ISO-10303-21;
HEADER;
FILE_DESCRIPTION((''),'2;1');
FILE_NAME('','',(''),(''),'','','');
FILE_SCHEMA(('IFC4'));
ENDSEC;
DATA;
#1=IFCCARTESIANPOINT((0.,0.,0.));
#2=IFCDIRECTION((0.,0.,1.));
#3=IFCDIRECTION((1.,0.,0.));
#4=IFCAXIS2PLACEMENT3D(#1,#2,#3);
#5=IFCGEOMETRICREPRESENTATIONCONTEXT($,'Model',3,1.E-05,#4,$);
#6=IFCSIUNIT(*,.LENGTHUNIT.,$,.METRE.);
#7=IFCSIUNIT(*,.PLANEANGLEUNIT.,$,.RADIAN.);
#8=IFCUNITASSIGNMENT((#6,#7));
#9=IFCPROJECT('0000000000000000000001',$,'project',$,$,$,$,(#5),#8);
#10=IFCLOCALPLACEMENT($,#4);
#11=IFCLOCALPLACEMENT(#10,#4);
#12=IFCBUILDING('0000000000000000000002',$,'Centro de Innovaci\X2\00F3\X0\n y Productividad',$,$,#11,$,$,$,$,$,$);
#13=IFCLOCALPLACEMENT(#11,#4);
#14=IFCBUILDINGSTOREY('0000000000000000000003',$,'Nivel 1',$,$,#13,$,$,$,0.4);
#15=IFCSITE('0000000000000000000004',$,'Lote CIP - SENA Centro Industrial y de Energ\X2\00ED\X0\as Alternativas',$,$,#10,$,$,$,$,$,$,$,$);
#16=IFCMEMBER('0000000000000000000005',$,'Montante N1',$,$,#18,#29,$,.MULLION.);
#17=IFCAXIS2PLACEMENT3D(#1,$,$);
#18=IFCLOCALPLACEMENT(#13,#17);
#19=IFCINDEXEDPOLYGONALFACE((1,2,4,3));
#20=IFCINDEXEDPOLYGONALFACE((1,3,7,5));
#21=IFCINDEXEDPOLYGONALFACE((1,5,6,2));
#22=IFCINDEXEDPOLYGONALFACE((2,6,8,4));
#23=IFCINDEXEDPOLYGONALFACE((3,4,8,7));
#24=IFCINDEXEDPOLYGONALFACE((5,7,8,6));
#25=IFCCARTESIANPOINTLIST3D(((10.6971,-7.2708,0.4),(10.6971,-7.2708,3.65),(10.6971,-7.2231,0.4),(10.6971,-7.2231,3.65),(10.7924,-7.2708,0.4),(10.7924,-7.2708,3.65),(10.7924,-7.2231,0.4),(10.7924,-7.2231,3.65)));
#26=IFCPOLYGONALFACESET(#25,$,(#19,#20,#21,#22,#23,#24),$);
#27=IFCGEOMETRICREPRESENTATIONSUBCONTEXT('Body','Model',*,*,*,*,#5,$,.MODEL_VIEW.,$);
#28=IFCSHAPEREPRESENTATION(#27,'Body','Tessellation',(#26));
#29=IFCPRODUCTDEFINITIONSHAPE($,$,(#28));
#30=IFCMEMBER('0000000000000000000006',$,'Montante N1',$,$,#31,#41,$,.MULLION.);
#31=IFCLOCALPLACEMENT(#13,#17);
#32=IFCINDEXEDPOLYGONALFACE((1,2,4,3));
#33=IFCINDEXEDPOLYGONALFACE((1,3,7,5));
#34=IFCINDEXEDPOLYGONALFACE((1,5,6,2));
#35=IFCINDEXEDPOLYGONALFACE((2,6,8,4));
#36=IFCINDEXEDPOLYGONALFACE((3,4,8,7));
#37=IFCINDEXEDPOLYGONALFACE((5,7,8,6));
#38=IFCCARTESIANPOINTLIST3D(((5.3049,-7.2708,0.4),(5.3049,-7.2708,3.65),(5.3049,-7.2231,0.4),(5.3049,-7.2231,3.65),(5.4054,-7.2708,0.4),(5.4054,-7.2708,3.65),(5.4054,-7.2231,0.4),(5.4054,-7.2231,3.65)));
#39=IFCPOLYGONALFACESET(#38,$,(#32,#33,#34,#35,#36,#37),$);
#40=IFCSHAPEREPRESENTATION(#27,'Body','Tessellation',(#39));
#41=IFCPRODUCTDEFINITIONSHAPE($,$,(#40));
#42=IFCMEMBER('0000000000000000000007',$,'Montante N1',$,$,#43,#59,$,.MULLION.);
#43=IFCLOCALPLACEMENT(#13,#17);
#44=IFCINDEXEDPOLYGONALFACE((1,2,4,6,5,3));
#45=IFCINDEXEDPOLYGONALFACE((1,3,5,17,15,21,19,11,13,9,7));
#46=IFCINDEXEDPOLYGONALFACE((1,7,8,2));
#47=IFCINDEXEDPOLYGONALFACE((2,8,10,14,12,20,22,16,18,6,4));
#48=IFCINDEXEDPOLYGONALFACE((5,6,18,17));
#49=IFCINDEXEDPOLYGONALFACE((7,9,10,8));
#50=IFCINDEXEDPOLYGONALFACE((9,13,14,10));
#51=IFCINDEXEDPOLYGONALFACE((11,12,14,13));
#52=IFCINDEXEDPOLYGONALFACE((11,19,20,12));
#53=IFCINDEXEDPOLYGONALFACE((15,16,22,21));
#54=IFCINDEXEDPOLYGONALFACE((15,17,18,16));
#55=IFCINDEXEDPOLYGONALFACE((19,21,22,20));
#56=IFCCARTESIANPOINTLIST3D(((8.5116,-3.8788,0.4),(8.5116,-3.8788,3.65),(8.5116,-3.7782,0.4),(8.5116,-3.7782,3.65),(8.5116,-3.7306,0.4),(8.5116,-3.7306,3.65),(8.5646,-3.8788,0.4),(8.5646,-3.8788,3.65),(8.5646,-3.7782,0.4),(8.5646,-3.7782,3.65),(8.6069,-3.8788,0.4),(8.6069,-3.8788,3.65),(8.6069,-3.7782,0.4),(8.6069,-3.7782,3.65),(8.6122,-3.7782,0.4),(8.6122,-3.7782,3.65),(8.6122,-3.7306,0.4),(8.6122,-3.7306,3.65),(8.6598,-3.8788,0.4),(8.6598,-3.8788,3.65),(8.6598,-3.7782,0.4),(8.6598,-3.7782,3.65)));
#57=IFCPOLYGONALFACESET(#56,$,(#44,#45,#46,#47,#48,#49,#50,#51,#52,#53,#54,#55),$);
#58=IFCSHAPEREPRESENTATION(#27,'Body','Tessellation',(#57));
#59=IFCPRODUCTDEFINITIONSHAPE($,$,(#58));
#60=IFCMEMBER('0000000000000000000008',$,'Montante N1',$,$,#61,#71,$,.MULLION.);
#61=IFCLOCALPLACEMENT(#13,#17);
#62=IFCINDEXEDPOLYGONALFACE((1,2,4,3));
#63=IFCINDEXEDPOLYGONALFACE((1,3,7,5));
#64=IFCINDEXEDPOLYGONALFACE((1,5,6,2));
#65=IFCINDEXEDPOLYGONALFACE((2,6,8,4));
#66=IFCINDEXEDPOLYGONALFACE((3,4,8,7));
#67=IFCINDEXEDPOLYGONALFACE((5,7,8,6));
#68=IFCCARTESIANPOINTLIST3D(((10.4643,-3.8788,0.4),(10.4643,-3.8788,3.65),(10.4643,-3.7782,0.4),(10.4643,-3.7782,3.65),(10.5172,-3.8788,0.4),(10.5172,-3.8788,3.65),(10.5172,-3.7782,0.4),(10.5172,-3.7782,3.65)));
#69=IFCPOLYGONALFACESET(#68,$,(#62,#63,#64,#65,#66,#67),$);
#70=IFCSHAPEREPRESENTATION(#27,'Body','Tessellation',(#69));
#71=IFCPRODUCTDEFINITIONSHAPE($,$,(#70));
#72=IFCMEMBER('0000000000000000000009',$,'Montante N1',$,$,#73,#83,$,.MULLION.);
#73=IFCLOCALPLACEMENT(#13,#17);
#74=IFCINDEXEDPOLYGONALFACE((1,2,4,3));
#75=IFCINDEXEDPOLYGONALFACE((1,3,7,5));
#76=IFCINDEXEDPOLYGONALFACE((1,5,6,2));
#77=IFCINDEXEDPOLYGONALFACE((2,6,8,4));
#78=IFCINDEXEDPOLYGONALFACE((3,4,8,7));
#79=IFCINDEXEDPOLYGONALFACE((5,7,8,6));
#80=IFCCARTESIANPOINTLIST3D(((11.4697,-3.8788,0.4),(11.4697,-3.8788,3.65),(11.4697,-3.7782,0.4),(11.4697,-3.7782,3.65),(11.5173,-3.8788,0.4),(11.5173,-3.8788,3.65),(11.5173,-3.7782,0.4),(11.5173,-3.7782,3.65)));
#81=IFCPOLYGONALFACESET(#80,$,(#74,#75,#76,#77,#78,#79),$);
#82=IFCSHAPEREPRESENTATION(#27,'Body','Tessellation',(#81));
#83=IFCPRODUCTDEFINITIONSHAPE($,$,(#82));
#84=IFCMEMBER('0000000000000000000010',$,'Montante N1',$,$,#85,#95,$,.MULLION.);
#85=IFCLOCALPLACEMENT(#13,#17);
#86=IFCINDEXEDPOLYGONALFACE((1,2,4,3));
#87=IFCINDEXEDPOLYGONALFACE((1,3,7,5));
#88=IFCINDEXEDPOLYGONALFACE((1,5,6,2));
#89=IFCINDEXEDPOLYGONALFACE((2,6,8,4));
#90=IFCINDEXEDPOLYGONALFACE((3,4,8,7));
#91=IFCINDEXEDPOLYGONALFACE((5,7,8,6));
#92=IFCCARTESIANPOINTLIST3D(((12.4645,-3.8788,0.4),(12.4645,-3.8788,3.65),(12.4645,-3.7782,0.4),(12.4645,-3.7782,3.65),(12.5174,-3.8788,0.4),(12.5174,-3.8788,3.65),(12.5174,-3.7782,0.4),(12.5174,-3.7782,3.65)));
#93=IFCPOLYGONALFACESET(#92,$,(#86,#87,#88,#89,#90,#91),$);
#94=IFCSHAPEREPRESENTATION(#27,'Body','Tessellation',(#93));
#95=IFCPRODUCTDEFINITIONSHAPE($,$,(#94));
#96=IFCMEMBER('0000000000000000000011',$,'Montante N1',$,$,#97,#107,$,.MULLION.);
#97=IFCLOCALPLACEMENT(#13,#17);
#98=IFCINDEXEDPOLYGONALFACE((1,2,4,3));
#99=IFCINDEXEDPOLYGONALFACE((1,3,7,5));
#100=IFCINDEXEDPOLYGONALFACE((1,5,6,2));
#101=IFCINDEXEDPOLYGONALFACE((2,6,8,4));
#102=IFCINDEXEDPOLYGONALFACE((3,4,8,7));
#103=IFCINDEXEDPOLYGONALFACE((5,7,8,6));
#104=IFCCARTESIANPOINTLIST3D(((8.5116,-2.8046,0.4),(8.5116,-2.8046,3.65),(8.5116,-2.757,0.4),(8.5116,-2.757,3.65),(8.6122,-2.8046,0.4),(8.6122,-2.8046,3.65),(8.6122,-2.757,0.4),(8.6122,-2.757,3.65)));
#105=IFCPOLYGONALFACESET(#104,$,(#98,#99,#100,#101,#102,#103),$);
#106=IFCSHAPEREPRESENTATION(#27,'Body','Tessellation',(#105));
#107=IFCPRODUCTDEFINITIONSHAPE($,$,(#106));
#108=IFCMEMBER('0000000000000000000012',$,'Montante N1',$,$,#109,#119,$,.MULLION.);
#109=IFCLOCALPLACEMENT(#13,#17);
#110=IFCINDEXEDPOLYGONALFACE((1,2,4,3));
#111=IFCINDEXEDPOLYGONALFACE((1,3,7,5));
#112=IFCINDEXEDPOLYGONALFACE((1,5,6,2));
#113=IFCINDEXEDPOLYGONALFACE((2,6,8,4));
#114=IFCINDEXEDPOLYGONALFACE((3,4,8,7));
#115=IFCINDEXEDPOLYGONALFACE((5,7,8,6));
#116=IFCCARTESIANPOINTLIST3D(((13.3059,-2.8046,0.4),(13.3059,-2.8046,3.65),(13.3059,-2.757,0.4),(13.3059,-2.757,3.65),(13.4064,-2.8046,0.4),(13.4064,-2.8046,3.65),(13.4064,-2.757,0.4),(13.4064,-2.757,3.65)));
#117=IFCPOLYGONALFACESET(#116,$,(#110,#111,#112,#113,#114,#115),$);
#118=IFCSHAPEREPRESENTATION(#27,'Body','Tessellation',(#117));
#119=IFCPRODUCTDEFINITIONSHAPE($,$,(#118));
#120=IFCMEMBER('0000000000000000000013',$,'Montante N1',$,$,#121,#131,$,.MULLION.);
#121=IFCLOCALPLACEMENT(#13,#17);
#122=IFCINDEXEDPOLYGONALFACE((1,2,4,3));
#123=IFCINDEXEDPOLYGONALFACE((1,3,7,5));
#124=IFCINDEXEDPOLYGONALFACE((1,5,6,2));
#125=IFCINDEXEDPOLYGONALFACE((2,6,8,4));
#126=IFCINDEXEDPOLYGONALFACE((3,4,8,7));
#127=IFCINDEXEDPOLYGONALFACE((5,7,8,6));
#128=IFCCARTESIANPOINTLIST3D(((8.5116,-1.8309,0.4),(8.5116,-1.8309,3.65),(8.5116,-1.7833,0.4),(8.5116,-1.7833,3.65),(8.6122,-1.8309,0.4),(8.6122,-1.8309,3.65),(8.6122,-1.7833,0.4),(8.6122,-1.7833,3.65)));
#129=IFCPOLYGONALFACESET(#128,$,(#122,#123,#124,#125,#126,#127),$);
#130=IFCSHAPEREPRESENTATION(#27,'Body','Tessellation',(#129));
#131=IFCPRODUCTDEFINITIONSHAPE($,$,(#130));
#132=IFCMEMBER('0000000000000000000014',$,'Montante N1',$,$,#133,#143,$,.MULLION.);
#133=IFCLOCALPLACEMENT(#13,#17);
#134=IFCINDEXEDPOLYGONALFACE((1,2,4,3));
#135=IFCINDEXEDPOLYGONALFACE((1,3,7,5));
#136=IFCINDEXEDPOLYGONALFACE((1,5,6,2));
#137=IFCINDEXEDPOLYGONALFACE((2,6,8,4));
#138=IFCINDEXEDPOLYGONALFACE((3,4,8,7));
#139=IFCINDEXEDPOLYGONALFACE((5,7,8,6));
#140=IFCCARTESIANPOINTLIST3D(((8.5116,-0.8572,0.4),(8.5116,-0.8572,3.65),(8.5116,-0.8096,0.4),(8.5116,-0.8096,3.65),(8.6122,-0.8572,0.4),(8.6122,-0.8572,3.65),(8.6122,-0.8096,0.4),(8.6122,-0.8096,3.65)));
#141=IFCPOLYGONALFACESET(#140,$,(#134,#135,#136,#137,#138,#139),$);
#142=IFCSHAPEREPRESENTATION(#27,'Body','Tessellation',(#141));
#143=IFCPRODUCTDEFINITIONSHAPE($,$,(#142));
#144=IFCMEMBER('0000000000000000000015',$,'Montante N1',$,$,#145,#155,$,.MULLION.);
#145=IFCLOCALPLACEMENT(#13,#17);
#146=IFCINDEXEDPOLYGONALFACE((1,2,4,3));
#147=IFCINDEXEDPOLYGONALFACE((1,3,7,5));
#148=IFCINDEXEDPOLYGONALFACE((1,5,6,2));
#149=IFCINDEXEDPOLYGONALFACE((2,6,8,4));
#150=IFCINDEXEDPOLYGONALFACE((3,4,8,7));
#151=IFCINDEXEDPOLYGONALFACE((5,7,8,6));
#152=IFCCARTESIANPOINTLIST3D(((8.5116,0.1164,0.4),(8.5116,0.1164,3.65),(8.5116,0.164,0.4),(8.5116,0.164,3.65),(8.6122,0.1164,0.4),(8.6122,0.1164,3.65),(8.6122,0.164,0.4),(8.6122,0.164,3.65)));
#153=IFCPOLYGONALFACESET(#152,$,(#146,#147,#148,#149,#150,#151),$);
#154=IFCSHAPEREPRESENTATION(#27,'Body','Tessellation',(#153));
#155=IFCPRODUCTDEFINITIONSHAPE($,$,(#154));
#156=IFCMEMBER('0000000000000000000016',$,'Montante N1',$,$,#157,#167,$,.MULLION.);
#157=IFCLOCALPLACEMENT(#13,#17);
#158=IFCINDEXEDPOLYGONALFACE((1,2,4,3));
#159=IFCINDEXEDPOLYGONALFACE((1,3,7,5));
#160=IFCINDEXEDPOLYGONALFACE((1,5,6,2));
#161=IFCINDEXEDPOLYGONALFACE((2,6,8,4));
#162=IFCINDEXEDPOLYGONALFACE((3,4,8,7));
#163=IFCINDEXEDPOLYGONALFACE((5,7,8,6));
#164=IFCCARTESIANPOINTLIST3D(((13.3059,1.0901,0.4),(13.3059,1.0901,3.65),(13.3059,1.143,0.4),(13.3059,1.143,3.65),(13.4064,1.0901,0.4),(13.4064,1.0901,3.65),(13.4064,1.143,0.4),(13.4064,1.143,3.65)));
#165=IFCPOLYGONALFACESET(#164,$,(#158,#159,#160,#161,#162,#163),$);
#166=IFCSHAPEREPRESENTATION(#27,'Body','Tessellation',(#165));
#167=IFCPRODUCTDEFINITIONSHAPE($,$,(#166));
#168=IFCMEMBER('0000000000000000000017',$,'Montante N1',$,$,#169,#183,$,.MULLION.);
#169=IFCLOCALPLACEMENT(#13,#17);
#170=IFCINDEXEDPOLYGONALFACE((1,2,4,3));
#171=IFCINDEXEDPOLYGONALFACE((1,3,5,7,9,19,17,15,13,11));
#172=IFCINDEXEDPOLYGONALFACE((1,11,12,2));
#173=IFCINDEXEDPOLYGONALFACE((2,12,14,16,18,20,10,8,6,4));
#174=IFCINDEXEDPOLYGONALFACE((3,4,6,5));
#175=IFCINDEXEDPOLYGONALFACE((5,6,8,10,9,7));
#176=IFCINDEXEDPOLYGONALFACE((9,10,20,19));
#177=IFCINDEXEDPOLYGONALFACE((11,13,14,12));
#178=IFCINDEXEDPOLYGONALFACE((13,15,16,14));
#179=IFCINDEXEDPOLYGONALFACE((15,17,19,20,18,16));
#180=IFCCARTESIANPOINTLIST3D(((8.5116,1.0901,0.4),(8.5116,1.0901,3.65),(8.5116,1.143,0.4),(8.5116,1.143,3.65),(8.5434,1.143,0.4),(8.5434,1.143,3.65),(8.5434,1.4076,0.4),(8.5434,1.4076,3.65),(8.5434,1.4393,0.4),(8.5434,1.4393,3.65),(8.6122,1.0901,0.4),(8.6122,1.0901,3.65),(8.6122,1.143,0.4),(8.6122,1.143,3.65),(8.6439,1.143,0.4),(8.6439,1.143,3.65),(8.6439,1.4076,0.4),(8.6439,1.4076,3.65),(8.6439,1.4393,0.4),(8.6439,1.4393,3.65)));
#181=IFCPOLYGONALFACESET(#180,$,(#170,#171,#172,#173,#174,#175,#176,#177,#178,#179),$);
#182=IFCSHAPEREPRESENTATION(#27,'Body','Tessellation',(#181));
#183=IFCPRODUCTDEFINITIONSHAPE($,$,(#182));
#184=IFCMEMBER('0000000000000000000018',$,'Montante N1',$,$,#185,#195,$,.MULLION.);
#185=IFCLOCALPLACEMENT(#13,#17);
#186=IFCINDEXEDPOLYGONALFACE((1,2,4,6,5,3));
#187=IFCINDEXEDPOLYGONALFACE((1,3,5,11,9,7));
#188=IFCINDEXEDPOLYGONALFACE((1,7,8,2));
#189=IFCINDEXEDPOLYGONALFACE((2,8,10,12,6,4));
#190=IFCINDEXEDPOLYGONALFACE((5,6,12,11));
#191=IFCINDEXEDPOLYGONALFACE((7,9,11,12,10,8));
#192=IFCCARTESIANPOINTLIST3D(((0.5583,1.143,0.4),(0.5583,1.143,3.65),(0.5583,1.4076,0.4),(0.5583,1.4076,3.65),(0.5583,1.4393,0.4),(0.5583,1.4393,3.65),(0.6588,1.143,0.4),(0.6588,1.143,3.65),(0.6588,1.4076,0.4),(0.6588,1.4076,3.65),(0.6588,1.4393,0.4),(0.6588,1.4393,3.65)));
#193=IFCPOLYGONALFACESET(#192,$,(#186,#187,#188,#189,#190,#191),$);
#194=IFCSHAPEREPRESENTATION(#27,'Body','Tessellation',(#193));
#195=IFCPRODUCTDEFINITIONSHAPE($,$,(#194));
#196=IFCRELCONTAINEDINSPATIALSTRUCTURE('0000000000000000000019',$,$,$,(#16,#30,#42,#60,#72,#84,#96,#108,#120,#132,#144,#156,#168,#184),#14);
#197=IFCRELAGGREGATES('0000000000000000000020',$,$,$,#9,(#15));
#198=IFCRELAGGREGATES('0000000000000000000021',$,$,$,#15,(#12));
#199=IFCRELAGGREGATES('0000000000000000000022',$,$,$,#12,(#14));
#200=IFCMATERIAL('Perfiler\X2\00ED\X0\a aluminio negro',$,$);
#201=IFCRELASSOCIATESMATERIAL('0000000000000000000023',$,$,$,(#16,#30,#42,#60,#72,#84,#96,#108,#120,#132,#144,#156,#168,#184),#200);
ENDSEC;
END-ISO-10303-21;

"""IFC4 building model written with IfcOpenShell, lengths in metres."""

from ifc_helpers import new_model, si_unit, frame, origin_with_axes, place, context, subcontext, project, spatial, polyline, outline, extrude, material, element, save


model = new_model("IFC4")

# Units and contexts
model_context = context("Model", 3, precision=1e-05, world=origin_with_axes())
body_context = subcontext(model_context, "Body", "Model", "MODEL_VIEW")
ifc_project = project(units=[si_unit("LENGTHUNIT", "METRE"), si_unit("PLANEANGLEUNIT", "RADIAN")], contexts=[model_context])

# Site, building, storey
site_placement = place(None, origin_with_axes())
site = spatial("IfcSite", under=ifc_project, at=site_placement, Name="Lote CIP - SENA Centro Industrial y de Energías Alternativas")
building_placement = place(site_placement, origin_with_axes())
building = spatial("IfcBuilding", under=site, at=building_placement, Name="Centro de Innovación y Productividad")
storey_placement = place(building_placement, origin_with_axes())
storey = spatial("IfcBuildingStorey", under=building, at=storey_placement, Name="Nivel 1", Elevation=0.4)

# Members
ifc_material = material(Name="Perfilería aluminio negro")
member_1_placement = place(storey_placement, origin_with_axes())
element("IfcMember", 1, at=member_1_placement, inside=storey, material=ifc_material, Name="Montante N1", PredefinedType="MULLION", context=body_context, shape_type="SweptSolid", body=[
    extrude(outline(polyline([(10.6971, -7.2231), (10.7924, -7.2231), (10.7924, -7.2708), (10.6971, -7.2708), (10.6971, -7.2231)])), frame((0.0, 0.0, 0.4)), (0.0, 0.0, 1.0), 3.25),
])
member_2_placement = place(storey_placement, origin_with_axes())
element("IfcMember", 2, at=member_2_placement, inside=storey, material=ifc_material, Name="Montante N1", PredefinedType="MULLION", context=body_context, shape_type="SweptSolid", body=[
    extrude(outline(polyline([(5.3049, -7.2231), (5.4054, -7.2231), (5.4054, -7.2708), (5.3049, -7.2708), (5.3049, -7.2231)])), frame((0.0, 0.0, 0.4)), (0.0, 0.0, 1.0), 3.25),
])
member_3_placement = place(storey_placement, origin_with_axes())
element("IfcMember", 3, at=member_3_placement, inside=storey, material=ifc_material, Name="Montante N1", PredefinedType="MULLION", context=body_context, shape_type="SweptSolid", body=[
    extrude(outline(polyline([(8.5116, -3.8788), (8.5116, -3.7782), (8.5116, -3.7306), (8.6122, -3.7306), (8.6122, -3.7782), (8.6598, -3.7782), (8.6598, -3.8788), (8.6069, -3.8788), (8.6069, -3.7782), (8.5646, -3.7782), (8.5646, -3.8788), (8.5116, -3.8788)])), frame((0.0, 0.0, 0.4)), (0.0, 0.0, 1.0), 3.25),
])
member_4_placement = place(storey_placement, origin_with_axes())
element("IfcMember", 4, at=member_4_placement, inside=storey, material=ifc_material, Name="Montante N1", PredefinedType="MULLION", context=body_context, shape_type="SweptSolid", body=[
    extrude(outline(polyline([(10.5172, -3.8788), (10.4643, -3.8788), (10.4643, -3.7782), (10.5172, -3.7782), (10.5172, -3.8788)])), frame((0.0, 0.0, 0.4)), (0.0, 0.0, 1.0), 3.25),
])
member_5_placement = place(storey_placement, origin_with_axes())
element("IfcMember", 5, at=member_5_placement, inside=storey, material=ifc_material, Name="Montante N1", PredefinedType="MULLION", context=body_context, shape_type="SweptSolid", body=[
    extrude(outline(polyline([(11.5173, -3.8788), (11.4697, -3.8788), (11.4697, -3.7782), (11.5173, -3.7782), (11.5173, -3.8788)])), frame((0.0, 0.0, 0.4)), (0.0, 0.0, 1.0), 3.25),
])
member_6_placement = place(storey_placement, origin_with_axes())
element("IfcMember", 6, at=member_6_placement, inside=storey, material=ifc_material, Name="Montante N1", PredefinedType="MULLION", context=body_context, shape_type="SweptSolid", body=[
    extrude(outline(polyline([(12.4645, -3.7782), (12.5174, -3.7782), (12.5174, -3.8788), (12.4645, -3.8788), (12.4645, -3.7782)])), frame((0.0, 0.0, 0.4)), (0.0, 0.0, 1.0), 3.25),
])
member_7_placement = place(storey_placement, origin_with_axes())
element("IfcMember", 7, at=member_7_placement, inside=storey, material=ifc_material, Name="Montante N1", PredefinedType="MULLION", context=body_context, shape_type="SweptSolid", body=[
    extrude(outline(polyline([(8.5116, -2.757), (8.6122, -2.757), (8.6122, -2.8046), (8.5116, -2.8046), (8.5116, -2.757)])), frame((0.0, 0.0, 0.4)), (0.0, 0.0, 1.0), 3.25),
])
member_8_placement = place(storey_placement, origin_with_axes())
element("IfcMember", 8, at=member_8_placement, inside=storey, material=ifc_material, Name="Montante N1", PredefinedType="MULLION", context=body_context, shape_type="SweptSolid", body=[
    extrude(outline(polyline([(13.4064, -2.757), (13.4064, -2.8046), (13.3059, -2.8046), (13.3059, -2.757), (13.4064, -2.757)])), frame((0.0, 0.0, 0.4)), (0.0, 0.0, 1.0), 3.25),
])
member_9_placement = place(storey_placement, origin_with_axes())
element("IfcMember", 9, at=member_9_placement, inside=storey, material=ifc_material, Name="Montante N1", PredefinedType="MULLION", context=body_context, shape_type="SweptSolid", body=[
    extrude(outline(polyline([(8.5116, -1.7833), (8.6122, -1.7833), (8.6122, -1.8309), (8.5116, -1.8309), (8.5116, -1.7833)])), frame((0.0, 0.0, 0.4)), (0.0, 0.0, 1.0), 3.25),
])
member_10_placement = place(storey_placement, origin_with_axes())
element("IfcMember", 10, at=member_10_placement, inside=storey, material=ifc_material, Name="Montante N1", PredefinedType="MULLION", context=body_context, shape_type="SweptSolid", body=[
    extrude(outline(polyline([(8.5116, -0.8096), (8.6122, -0.8096), (8.6122, -0.8572), (8.5116, -0.8572), (8.5116, -0.8096)])), frame((0.0, 0.0, 0.4)), (0.0, 0.0, 1.0), 3.25),
])
member_11_placement = place(storey_placement, origin_with_axes())
element("IfcMember", 11, at=member_11_placement, inside=storey, material=ifc_material, Name="Montante N1", PredefinedType="MULLION", context=body_context, shape_type="SweptSolid", body=[
    extrude(outline(polyline([(8.5116, 0.1164), (8.5116, 0.164), (8.6122, 0.164), (8.6122, 0.1164), (8.5116, 0.1164)])), frame((0.0, 0.0, 0.4)), (0.0, 0.0, 1.0), 3.25),
])
member_12_placement = place(storey_placement, origin_with_axes())
element("IfcMember", 12, at=member_12_placement, inside=storey, material=ifc_material, Name="Montante N1", PredefinedType="MULLION", context=body_context, shape_type="SweptSolid", body=[
    extrude(outline(polyline([(13.3059, 1.0901), (13.3059, 1.143), (13.4064, 1.143), (13.4064, 1.0901), (13.3059, 1.0901)])), frame((0.0, 0.0, 0.4)), (0.0, 0.0, 1.0), 3.25),
])
member_13_placement = place(storey_placement, origin_with_axes())
element("IfcMember", 13, at=member_13_placement, inside=storey, material=ifc_material, Name="Montante N1", PredefinedType="MULLION", context=body_context, shape_type="SweptSolid", body=[
    extrude(outline(polyline([(8.5116, 1.0901), (8.5116, 1.143), (8.5434, 1.143), (8.5434, 1.4076), (8.5434, 1.4393), (8.6439, 1.4393), (8.6439, 1.4076), (8.6439, 1.143), (8.6122, 1.143), (8.6122, 1.0901), (8.5116, 1.0901)])), frame((0.0, 0.0, 0.4)), (0.0, 0.0, 1.0), 3.25),
])
member_14_placement = place(storey_placement, origin_with_axes())
element("IfcMember", 14, at=member_14_placement, inside=storey, material=ifc_material, Name="Montante N1", PredefinedType="MULLION", context=body_context, shape_type="SweptSolid", body=[
    extrude(outline(polyline([(0.5583, 1.143), (0.5583, 1.4076), (0.5583, 1.4393), (0.6588, 1.4393), (0.6588, 1.4076), (0.6588, 1.143), (0.5583, 1.143)])), frame((0.0, 0.0, 0.4)), (0.0, 0.0, 1.0), 3.25),
])

save(model, "model.ifc")
